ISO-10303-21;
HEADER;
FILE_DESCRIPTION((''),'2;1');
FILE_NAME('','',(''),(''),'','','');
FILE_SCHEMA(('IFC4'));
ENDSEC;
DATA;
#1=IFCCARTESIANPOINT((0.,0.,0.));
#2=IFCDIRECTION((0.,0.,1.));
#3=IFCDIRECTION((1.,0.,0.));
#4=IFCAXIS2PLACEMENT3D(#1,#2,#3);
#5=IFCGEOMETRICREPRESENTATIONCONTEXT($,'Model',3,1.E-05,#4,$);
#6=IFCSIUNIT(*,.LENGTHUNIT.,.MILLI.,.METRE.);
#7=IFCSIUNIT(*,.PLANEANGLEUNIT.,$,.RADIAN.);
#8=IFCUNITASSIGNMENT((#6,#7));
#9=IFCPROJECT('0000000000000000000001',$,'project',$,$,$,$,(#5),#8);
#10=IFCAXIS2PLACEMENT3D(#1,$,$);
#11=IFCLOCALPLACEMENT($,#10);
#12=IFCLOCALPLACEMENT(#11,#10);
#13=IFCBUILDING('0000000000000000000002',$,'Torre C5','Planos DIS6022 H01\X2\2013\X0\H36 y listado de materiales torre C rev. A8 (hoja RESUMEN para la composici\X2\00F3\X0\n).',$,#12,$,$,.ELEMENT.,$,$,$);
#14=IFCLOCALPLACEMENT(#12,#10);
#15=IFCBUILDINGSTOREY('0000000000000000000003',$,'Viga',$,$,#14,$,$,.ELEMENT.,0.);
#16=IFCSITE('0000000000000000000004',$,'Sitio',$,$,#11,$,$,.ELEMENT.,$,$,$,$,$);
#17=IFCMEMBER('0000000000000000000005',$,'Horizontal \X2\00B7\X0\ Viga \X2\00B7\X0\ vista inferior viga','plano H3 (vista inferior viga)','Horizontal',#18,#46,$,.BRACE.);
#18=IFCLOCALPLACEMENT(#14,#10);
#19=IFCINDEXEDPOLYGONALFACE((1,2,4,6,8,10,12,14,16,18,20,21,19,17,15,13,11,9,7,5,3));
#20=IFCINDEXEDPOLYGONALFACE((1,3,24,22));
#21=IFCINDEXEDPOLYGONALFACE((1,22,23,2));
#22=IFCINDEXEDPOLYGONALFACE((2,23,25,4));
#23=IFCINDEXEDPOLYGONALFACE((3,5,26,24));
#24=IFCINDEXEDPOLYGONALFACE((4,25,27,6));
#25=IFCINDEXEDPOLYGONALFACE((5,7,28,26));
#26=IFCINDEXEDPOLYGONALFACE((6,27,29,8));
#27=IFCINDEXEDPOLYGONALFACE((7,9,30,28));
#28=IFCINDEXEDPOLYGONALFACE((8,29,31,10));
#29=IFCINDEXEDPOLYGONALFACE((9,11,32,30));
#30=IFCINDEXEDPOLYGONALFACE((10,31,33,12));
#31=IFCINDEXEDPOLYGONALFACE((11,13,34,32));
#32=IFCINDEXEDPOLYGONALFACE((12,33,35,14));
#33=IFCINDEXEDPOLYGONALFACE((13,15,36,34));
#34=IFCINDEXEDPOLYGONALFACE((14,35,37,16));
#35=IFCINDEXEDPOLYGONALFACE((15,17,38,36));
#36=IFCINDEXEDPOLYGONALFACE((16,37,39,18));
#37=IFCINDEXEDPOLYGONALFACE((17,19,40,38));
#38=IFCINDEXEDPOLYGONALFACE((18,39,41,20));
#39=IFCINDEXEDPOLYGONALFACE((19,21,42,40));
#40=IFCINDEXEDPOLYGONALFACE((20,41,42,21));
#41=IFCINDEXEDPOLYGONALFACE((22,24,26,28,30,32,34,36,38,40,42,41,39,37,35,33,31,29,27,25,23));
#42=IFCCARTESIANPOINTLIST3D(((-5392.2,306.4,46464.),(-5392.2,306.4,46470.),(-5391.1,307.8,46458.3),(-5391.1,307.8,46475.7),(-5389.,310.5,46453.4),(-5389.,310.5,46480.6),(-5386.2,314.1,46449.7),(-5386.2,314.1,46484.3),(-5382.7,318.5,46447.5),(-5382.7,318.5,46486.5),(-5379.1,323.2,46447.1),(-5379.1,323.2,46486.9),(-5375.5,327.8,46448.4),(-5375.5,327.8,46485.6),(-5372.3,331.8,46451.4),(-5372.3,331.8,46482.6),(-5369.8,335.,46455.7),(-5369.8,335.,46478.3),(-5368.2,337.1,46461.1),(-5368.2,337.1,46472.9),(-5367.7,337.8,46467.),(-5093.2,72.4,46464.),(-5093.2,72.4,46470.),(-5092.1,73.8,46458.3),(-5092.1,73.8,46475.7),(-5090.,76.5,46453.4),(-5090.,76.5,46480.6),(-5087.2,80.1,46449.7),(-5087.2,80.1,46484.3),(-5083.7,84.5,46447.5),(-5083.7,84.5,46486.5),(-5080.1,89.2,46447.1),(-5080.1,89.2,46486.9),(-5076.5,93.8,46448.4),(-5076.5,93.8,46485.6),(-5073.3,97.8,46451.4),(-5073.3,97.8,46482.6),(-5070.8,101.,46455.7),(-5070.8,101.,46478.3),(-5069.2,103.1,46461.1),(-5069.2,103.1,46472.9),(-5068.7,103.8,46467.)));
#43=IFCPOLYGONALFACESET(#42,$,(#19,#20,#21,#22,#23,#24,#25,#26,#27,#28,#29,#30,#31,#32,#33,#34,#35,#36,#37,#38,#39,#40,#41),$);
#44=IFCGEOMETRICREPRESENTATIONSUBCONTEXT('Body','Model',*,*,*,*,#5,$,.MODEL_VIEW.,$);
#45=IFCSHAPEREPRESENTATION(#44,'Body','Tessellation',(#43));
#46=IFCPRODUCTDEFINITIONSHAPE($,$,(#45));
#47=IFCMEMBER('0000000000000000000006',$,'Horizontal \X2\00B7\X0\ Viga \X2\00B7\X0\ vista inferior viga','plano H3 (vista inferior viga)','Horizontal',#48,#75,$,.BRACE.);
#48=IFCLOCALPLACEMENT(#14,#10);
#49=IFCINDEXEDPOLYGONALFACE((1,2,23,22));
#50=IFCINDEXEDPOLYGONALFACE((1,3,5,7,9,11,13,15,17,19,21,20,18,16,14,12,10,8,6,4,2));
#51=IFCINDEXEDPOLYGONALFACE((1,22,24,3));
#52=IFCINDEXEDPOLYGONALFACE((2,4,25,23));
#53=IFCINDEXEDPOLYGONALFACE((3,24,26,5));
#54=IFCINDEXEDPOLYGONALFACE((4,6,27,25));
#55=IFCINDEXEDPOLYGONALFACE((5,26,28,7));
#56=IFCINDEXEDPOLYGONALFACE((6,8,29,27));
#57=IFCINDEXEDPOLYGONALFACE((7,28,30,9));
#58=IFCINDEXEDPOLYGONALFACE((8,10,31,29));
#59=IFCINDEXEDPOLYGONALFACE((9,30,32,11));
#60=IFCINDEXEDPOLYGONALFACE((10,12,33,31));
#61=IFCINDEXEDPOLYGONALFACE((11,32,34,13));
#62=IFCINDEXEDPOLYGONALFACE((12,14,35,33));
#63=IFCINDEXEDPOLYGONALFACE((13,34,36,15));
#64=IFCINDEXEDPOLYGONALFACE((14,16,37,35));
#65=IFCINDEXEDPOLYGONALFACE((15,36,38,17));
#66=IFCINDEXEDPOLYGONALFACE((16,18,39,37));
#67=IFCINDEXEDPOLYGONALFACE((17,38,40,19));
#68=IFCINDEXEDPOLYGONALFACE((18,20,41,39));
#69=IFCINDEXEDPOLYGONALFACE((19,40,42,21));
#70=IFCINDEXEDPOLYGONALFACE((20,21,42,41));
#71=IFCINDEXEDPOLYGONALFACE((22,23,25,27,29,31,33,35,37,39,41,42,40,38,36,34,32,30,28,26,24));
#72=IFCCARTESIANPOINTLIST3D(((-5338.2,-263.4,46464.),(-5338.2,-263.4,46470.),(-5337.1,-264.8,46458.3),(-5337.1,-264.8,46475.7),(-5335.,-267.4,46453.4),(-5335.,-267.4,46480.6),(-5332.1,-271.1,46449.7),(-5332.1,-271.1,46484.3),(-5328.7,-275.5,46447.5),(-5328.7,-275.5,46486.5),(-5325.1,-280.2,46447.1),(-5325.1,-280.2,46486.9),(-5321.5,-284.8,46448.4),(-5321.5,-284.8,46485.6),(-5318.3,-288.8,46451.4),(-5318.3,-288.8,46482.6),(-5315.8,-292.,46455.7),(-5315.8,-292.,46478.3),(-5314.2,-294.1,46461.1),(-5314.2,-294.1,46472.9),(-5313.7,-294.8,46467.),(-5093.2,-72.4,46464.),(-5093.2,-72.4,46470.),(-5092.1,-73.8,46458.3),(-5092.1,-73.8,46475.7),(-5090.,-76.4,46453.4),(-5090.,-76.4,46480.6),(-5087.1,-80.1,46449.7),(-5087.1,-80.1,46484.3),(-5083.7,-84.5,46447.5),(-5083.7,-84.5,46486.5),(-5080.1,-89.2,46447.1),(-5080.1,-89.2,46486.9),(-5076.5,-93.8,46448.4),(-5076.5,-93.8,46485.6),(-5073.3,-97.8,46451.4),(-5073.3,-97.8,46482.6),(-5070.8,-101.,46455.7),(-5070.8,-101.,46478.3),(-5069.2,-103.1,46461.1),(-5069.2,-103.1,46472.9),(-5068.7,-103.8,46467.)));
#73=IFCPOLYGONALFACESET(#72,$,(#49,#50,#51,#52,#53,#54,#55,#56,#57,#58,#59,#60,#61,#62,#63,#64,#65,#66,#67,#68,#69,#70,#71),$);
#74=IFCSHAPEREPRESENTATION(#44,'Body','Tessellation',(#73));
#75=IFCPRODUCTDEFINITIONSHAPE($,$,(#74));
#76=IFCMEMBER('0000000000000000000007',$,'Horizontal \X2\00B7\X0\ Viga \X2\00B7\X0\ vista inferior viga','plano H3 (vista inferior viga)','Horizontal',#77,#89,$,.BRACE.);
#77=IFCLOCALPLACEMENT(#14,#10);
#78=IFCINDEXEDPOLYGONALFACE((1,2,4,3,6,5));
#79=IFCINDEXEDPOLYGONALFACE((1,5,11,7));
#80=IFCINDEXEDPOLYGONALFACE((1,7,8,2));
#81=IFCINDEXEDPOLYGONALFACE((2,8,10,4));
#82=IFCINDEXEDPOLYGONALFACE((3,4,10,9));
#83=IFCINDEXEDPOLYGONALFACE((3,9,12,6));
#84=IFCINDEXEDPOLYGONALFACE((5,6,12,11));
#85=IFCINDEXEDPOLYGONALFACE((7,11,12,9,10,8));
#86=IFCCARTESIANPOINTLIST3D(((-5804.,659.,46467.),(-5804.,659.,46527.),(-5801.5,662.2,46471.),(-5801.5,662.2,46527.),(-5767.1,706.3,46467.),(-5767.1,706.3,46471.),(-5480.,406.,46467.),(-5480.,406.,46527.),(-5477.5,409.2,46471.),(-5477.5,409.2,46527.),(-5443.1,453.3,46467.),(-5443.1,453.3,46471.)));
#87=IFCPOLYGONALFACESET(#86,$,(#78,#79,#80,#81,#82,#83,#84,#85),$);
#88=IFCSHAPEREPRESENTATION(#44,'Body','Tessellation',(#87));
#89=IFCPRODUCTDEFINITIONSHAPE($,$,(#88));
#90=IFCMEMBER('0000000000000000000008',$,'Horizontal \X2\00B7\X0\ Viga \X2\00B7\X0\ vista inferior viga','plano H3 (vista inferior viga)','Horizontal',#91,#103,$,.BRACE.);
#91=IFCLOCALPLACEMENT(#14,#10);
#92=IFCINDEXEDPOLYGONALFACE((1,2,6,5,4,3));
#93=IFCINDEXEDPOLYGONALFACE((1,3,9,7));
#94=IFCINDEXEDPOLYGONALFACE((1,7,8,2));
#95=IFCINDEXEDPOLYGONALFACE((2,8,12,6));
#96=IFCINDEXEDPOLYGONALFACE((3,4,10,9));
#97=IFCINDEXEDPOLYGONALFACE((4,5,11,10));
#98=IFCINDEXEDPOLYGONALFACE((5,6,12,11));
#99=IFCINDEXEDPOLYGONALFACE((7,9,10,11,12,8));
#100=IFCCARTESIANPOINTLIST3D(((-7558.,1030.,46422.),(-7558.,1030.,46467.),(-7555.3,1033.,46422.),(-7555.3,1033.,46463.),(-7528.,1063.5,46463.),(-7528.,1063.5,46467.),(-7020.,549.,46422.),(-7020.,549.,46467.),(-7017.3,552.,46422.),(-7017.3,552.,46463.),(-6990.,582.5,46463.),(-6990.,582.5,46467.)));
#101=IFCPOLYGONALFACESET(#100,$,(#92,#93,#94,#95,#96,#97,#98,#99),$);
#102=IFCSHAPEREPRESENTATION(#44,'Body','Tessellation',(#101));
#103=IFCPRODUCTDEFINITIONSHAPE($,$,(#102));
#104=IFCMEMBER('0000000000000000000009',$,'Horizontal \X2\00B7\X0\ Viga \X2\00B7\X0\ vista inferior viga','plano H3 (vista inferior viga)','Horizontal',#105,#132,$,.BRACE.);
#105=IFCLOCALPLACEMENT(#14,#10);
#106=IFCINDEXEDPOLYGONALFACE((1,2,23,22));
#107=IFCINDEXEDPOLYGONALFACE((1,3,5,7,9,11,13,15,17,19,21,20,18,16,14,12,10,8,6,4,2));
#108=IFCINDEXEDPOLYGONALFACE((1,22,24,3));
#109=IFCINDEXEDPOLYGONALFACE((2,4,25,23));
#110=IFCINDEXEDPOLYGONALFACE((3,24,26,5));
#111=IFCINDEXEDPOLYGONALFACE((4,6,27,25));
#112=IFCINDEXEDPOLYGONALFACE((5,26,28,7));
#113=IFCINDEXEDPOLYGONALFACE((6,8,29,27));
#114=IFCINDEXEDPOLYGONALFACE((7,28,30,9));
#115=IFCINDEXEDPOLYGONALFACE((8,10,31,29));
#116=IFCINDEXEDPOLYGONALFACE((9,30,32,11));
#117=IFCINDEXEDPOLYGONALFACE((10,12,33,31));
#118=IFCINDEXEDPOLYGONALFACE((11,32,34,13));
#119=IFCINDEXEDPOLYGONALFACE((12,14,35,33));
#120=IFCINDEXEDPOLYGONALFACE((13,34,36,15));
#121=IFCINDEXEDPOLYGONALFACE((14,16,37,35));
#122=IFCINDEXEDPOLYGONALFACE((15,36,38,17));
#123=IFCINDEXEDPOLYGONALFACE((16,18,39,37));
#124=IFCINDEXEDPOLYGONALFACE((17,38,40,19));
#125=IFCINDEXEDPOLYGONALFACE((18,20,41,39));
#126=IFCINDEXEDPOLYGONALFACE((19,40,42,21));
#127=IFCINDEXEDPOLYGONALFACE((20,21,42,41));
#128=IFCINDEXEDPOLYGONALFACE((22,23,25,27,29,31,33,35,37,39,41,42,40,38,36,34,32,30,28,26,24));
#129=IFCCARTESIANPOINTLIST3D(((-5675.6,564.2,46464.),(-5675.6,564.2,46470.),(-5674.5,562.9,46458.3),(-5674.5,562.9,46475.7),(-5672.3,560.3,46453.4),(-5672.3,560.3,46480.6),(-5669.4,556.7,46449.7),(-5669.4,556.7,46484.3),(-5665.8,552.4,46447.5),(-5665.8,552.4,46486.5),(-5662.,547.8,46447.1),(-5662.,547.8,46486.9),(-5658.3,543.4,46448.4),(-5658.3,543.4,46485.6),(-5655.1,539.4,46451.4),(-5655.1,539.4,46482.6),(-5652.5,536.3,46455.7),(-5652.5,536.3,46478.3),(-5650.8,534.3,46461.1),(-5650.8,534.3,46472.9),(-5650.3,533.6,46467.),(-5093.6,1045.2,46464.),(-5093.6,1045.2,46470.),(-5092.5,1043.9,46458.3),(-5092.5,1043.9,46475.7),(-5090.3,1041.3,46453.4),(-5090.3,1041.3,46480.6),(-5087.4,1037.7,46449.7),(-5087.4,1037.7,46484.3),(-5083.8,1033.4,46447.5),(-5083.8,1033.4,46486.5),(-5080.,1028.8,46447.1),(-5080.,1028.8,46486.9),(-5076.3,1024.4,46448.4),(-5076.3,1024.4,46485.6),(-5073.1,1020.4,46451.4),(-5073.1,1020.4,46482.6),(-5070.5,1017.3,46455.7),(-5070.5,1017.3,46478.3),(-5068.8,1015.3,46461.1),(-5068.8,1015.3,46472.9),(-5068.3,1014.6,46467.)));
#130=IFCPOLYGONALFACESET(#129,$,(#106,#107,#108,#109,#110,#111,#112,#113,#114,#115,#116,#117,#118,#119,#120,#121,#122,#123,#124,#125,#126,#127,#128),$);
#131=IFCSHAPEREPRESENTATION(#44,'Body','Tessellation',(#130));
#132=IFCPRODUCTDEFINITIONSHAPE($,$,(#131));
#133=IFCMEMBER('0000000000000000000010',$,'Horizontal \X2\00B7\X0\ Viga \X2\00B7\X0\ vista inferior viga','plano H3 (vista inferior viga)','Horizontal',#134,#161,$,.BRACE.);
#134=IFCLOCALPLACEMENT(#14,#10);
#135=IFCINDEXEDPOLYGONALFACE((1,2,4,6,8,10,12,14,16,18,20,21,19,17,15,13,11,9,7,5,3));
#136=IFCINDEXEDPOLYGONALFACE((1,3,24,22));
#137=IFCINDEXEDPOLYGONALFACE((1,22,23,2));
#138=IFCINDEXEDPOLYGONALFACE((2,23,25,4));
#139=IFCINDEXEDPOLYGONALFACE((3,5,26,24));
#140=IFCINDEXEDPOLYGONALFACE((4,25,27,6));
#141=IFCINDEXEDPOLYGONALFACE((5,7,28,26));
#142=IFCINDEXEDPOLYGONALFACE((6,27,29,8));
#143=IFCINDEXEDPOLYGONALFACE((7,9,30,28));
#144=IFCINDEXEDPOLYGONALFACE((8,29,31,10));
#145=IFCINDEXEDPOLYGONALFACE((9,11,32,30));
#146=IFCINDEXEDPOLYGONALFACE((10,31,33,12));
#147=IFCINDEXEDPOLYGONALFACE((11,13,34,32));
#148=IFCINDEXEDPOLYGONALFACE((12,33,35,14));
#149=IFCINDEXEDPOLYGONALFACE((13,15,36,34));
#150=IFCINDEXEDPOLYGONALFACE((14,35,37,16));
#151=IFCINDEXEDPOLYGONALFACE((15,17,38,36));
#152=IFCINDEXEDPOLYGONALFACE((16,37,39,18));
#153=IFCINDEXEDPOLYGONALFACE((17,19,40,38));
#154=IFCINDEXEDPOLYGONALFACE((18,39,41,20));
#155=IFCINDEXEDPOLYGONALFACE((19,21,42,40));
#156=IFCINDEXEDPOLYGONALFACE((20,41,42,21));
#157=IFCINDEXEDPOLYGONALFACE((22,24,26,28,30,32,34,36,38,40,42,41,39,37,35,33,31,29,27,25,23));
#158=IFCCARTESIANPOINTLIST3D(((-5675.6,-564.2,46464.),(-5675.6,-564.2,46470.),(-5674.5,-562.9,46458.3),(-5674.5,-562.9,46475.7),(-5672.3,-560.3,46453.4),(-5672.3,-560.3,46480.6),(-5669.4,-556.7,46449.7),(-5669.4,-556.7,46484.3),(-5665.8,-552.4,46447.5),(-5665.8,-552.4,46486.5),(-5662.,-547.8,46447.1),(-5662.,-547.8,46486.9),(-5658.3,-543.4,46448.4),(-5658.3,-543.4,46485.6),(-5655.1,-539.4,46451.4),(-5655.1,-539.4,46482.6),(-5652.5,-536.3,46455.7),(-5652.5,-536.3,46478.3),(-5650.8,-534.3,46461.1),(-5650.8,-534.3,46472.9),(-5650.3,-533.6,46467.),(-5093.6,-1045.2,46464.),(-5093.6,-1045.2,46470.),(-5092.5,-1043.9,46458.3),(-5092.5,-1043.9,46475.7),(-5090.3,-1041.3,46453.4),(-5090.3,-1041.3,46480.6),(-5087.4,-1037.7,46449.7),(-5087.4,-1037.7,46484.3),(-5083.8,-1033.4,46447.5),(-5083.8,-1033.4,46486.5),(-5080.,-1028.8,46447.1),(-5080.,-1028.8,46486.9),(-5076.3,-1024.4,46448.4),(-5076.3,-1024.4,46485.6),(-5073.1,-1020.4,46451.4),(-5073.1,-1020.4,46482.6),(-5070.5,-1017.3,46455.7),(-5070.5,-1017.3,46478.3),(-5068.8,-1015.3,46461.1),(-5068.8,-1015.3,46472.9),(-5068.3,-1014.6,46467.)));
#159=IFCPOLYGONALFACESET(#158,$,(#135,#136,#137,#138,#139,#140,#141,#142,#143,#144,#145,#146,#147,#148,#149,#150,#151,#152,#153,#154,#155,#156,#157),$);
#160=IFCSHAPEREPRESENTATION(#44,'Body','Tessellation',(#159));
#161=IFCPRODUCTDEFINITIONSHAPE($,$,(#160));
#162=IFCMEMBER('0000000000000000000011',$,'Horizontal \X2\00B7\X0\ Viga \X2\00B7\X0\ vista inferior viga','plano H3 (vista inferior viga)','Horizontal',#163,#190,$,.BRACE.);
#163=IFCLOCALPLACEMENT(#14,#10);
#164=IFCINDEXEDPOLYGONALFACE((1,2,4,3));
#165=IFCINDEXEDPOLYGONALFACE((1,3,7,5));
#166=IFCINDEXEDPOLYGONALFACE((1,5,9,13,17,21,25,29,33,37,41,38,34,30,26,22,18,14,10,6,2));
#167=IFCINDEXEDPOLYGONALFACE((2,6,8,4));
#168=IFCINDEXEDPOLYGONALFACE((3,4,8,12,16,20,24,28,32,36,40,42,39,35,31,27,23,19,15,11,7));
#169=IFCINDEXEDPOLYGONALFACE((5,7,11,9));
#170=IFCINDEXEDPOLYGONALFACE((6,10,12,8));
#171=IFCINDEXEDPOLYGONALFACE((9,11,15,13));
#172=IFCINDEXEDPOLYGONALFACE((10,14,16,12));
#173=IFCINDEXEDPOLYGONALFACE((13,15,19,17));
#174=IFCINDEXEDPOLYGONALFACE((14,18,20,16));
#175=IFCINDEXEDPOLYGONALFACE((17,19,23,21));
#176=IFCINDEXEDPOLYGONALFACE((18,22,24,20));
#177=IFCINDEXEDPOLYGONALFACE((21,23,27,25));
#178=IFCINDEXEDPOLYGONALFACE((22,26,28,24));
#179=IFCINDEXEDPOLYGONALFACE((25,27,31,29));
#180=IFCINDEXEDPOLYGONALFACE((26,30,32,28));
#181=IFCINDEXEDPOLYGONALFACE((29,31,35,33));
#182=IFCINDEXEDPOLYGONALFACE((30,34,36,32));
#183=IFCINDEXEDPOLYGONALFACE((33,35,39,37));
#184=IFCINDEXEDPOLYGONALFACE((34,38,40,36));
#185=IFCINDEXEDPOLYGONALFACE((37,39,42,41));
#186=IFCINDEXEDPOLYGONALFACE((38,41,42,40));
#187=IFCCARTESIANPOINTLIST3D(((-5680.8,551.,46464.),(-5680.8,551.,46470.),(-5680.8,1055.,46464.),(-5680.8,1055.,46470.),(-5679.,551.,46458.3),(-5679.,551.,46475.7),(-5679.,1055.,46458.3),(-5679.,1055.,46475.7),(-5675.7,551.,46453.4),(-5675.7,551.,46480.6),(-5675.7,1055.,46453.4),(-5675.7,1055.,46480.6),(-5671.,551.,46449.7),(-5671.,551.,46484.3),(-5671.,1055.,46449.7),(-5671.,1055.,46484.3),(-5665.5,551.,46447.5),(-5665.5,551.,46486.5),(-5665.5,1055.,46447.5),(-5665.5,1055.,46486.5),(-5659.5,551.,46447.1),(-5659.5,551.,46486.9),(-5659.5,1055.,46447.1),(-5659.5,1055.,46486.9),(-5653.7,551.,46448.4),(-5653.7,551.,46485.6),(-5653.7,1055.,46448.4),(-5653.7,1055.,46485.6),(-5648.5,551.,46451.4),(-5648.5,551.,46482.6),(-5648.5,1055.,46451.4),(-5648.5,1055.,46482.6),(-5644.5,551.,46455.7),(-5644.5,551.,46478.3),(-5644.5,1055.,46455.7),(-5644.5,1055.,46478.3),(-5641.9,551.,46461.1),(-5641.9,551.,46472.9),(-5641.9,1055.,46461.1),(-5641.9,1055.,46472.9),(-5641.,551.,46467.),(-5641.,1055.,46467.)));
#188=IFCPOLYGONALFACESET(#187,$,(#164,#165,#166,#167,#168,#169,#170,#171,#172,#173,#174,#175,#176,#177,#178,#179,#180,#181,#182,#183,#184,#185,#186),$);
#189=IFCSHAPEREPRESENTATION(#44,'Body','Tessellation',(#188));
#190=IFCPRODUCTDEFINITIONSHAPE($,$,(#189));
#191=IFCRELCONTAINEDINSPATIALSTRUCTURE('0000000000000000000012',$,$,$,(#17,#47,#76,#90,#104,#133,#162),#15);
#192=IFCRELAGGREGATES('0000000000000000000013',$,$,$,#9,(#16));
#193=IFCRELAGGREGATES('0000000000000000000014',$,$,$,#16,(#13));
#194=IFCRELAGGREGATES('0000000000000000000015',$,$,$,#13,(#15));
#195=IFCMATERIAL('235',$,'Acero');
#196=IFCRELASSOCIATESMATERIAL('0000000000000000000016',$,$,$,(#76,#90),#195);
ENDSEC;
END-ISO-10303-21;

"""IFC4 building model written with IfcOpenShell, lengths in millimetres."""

from ifc_helpers import new_model, si_unit, frame, frame_2d, origin, origin_with_axes, place, context, subcontext, project, spatial, circle, l_section, extrude, material, element, save


model = new_model("IFC4")

# Units and contexts
model_context = context("Model", 3, precision=1e-05, world=origin_with_axes())
body_context = subcontext(model_context, "Body", "Model", "MODEL_VIEW")
ifc_project = project(units=[si_unit("LENGTHUNIT", "METRE", prefix="MILLI"), si_unit("PLANEANGLEUNIT", "RADIAN")], contexts=[model_context])

# Site, building, storey
site_placement = place(None, origin())
site = spatial("IfcSite", under=ifc_project, at=site_placement, Name="Sitio", CompositionType="ELEMENT")
building_placement = place(site_placement, origin())
building = spatial("IfcBuilding", under=site, at=building_placement, Name="Torre C5", Description="Planos DIS6022 H01–H36 y listado de materiales torre C rev. A8 (hoja RESUMEN para la composición).", CompositionType="ELEMENT")
storey_placement = place(building_placement, origin())
storey = spatial("IfcBuildingStorey", under=building, at=storey_placement, Name="Viga", CompositionType="ELEMENT", Elevation=0.0)

# Members
ifc_material_1 = material(Name="235", Category="Acero")
member_1_placement = place(storey_placement, frame((-5081.0, 88.0, 46467.0), z_axis=(-0.787505, 0.616308, 0.0), x_axis=(0.616308, 0.787505, 0.0)))
element("IfcMember", 1, at=member_1_placement, inside=storey, Name="Horizontal · Viga · vista inferior viga", Description="plano H3 (vista inferior viga)", ObjectType="Horizontal", PredefinedType="BRACE", context=body_context, shape_type="SweptSolid", body=[
    extrude(circle(Radius=20.0), None, (0.0, 0.0, 1.0), 379.7),
])
member_2_placement = place(storey_placement, frame((-5081.0, -88.0, 46467.0), z_axis=(-0.788658, -0.614832, 0.0), x_axis=(0.614832, -0.788658, 0.0)))
element("IfcMember", 2, at=member_2_placement, inside=storey, Name="Horizontal · Viga · vista inferior viga", Description="plano H3 (vista inferior viga)", ObjectType="Horizontal", PredefinedType="BRACE", context=body_context, shape_type="SweptSolid", body=[
    extrude(circle(Radius=20.0), None, (0.0, 0.0, 1.0), 310.7),
])
member_3_placement = place(storey_placement, frame((-5804.0, 659.0, 46467.0), z_axis=(0.788172, -0.615455, 0.0), x_axis=(0.615455, 0.788172, 0.0)))
element("IfcMember", 3, at=member_3_placement, inside=storey, material=ifc_material_1, Name="Horizontal · Viga · vista inferior viga", Description="plano H3 (vista inferior viga)", ObjectType="Horizontal", PredefinedType="BRACE", context=body_context, shape_type="SweptSolid", body=[
    extrude(l_section(Depth=60.0, Width=60.0, Thickness=4.0, at=frame_2d((30.0, 30.0))), None, (0.0, 0.0, 1.0), 411.1),
])
member_4_placement = place(storey_placement, frame((-7020.0, 549.0, 46467.0), z_axis=(-0.745495, 0.666511, 0.0), x_axis=(0.666511, 0.745495, 0.0)))
element("IfcMember", 4, at=member_4_placement, inside=storey, material=ifc_material_1, Name="Horizontal · Viga · vista inferior viga", Description="plano H3 (vista inferior viga)", ObjectType="Horizontal", PredefinedType="BRACE", context=body_context, shape_type="SweptSolid", body=[
    extrude(l_section(Depth=45.0, Width=45.0, Thickness=4.0, at=frame_2d((22.5, 22.5))), None, (0.0, 0.0, 1.0), 721.7),
])
for number, where, z_axis, x_axis, name in (
    (5, (-5663.0, 549.0, 46467.0), (0.77082, 0.637053, 0.0), (0.637053, -0.77082, 0.0), "Horizontal · Viga · vista inferior viga"),
    (6, (-5663.0, -549.0, 46467.0), (0.77082, -0.637053, 0.0), (0.637053, 0.77082, 0.0), "Horizontal · Viga · vista inferior viga"),
):
    element("IfcMember", number, at=place(storey_placement, frame(where, z_axis=z_axis, x_axis=x_axis)), inside=storey, Name=name, Description="plano H3 (vista inferior viga)", ObjectType="Horizontal", PredefinedType="BRACE", context=body_context, shape_type="SweptSolid", body=[
        extrude(circle(Radius=20.0), None, (0.0, 0.0, 1.0), 755.0),
    ])
member_5_placement = place(storey_placement, frame((-5661.0, 551.0, 46467.0), z_axis=(0.0, 1.0, 0.0), x_axis=(1.0, 0.0, 0.0)))
element("IfcMember", 7, at=member_5_placement, inside=storey, Name="Horizontal · Viga · vista inferior viga", Description="plano H3 (vista inferior viga)", ObjectType="Horizontal", PredefinedType="BRACE", context=body_context, shape_type="SweptSolid", body=[
    extrude(circle(Radius=20.0), None, (0.0, 0.0, 1.0), 504.0),
])

save(model, "model.ifc")
